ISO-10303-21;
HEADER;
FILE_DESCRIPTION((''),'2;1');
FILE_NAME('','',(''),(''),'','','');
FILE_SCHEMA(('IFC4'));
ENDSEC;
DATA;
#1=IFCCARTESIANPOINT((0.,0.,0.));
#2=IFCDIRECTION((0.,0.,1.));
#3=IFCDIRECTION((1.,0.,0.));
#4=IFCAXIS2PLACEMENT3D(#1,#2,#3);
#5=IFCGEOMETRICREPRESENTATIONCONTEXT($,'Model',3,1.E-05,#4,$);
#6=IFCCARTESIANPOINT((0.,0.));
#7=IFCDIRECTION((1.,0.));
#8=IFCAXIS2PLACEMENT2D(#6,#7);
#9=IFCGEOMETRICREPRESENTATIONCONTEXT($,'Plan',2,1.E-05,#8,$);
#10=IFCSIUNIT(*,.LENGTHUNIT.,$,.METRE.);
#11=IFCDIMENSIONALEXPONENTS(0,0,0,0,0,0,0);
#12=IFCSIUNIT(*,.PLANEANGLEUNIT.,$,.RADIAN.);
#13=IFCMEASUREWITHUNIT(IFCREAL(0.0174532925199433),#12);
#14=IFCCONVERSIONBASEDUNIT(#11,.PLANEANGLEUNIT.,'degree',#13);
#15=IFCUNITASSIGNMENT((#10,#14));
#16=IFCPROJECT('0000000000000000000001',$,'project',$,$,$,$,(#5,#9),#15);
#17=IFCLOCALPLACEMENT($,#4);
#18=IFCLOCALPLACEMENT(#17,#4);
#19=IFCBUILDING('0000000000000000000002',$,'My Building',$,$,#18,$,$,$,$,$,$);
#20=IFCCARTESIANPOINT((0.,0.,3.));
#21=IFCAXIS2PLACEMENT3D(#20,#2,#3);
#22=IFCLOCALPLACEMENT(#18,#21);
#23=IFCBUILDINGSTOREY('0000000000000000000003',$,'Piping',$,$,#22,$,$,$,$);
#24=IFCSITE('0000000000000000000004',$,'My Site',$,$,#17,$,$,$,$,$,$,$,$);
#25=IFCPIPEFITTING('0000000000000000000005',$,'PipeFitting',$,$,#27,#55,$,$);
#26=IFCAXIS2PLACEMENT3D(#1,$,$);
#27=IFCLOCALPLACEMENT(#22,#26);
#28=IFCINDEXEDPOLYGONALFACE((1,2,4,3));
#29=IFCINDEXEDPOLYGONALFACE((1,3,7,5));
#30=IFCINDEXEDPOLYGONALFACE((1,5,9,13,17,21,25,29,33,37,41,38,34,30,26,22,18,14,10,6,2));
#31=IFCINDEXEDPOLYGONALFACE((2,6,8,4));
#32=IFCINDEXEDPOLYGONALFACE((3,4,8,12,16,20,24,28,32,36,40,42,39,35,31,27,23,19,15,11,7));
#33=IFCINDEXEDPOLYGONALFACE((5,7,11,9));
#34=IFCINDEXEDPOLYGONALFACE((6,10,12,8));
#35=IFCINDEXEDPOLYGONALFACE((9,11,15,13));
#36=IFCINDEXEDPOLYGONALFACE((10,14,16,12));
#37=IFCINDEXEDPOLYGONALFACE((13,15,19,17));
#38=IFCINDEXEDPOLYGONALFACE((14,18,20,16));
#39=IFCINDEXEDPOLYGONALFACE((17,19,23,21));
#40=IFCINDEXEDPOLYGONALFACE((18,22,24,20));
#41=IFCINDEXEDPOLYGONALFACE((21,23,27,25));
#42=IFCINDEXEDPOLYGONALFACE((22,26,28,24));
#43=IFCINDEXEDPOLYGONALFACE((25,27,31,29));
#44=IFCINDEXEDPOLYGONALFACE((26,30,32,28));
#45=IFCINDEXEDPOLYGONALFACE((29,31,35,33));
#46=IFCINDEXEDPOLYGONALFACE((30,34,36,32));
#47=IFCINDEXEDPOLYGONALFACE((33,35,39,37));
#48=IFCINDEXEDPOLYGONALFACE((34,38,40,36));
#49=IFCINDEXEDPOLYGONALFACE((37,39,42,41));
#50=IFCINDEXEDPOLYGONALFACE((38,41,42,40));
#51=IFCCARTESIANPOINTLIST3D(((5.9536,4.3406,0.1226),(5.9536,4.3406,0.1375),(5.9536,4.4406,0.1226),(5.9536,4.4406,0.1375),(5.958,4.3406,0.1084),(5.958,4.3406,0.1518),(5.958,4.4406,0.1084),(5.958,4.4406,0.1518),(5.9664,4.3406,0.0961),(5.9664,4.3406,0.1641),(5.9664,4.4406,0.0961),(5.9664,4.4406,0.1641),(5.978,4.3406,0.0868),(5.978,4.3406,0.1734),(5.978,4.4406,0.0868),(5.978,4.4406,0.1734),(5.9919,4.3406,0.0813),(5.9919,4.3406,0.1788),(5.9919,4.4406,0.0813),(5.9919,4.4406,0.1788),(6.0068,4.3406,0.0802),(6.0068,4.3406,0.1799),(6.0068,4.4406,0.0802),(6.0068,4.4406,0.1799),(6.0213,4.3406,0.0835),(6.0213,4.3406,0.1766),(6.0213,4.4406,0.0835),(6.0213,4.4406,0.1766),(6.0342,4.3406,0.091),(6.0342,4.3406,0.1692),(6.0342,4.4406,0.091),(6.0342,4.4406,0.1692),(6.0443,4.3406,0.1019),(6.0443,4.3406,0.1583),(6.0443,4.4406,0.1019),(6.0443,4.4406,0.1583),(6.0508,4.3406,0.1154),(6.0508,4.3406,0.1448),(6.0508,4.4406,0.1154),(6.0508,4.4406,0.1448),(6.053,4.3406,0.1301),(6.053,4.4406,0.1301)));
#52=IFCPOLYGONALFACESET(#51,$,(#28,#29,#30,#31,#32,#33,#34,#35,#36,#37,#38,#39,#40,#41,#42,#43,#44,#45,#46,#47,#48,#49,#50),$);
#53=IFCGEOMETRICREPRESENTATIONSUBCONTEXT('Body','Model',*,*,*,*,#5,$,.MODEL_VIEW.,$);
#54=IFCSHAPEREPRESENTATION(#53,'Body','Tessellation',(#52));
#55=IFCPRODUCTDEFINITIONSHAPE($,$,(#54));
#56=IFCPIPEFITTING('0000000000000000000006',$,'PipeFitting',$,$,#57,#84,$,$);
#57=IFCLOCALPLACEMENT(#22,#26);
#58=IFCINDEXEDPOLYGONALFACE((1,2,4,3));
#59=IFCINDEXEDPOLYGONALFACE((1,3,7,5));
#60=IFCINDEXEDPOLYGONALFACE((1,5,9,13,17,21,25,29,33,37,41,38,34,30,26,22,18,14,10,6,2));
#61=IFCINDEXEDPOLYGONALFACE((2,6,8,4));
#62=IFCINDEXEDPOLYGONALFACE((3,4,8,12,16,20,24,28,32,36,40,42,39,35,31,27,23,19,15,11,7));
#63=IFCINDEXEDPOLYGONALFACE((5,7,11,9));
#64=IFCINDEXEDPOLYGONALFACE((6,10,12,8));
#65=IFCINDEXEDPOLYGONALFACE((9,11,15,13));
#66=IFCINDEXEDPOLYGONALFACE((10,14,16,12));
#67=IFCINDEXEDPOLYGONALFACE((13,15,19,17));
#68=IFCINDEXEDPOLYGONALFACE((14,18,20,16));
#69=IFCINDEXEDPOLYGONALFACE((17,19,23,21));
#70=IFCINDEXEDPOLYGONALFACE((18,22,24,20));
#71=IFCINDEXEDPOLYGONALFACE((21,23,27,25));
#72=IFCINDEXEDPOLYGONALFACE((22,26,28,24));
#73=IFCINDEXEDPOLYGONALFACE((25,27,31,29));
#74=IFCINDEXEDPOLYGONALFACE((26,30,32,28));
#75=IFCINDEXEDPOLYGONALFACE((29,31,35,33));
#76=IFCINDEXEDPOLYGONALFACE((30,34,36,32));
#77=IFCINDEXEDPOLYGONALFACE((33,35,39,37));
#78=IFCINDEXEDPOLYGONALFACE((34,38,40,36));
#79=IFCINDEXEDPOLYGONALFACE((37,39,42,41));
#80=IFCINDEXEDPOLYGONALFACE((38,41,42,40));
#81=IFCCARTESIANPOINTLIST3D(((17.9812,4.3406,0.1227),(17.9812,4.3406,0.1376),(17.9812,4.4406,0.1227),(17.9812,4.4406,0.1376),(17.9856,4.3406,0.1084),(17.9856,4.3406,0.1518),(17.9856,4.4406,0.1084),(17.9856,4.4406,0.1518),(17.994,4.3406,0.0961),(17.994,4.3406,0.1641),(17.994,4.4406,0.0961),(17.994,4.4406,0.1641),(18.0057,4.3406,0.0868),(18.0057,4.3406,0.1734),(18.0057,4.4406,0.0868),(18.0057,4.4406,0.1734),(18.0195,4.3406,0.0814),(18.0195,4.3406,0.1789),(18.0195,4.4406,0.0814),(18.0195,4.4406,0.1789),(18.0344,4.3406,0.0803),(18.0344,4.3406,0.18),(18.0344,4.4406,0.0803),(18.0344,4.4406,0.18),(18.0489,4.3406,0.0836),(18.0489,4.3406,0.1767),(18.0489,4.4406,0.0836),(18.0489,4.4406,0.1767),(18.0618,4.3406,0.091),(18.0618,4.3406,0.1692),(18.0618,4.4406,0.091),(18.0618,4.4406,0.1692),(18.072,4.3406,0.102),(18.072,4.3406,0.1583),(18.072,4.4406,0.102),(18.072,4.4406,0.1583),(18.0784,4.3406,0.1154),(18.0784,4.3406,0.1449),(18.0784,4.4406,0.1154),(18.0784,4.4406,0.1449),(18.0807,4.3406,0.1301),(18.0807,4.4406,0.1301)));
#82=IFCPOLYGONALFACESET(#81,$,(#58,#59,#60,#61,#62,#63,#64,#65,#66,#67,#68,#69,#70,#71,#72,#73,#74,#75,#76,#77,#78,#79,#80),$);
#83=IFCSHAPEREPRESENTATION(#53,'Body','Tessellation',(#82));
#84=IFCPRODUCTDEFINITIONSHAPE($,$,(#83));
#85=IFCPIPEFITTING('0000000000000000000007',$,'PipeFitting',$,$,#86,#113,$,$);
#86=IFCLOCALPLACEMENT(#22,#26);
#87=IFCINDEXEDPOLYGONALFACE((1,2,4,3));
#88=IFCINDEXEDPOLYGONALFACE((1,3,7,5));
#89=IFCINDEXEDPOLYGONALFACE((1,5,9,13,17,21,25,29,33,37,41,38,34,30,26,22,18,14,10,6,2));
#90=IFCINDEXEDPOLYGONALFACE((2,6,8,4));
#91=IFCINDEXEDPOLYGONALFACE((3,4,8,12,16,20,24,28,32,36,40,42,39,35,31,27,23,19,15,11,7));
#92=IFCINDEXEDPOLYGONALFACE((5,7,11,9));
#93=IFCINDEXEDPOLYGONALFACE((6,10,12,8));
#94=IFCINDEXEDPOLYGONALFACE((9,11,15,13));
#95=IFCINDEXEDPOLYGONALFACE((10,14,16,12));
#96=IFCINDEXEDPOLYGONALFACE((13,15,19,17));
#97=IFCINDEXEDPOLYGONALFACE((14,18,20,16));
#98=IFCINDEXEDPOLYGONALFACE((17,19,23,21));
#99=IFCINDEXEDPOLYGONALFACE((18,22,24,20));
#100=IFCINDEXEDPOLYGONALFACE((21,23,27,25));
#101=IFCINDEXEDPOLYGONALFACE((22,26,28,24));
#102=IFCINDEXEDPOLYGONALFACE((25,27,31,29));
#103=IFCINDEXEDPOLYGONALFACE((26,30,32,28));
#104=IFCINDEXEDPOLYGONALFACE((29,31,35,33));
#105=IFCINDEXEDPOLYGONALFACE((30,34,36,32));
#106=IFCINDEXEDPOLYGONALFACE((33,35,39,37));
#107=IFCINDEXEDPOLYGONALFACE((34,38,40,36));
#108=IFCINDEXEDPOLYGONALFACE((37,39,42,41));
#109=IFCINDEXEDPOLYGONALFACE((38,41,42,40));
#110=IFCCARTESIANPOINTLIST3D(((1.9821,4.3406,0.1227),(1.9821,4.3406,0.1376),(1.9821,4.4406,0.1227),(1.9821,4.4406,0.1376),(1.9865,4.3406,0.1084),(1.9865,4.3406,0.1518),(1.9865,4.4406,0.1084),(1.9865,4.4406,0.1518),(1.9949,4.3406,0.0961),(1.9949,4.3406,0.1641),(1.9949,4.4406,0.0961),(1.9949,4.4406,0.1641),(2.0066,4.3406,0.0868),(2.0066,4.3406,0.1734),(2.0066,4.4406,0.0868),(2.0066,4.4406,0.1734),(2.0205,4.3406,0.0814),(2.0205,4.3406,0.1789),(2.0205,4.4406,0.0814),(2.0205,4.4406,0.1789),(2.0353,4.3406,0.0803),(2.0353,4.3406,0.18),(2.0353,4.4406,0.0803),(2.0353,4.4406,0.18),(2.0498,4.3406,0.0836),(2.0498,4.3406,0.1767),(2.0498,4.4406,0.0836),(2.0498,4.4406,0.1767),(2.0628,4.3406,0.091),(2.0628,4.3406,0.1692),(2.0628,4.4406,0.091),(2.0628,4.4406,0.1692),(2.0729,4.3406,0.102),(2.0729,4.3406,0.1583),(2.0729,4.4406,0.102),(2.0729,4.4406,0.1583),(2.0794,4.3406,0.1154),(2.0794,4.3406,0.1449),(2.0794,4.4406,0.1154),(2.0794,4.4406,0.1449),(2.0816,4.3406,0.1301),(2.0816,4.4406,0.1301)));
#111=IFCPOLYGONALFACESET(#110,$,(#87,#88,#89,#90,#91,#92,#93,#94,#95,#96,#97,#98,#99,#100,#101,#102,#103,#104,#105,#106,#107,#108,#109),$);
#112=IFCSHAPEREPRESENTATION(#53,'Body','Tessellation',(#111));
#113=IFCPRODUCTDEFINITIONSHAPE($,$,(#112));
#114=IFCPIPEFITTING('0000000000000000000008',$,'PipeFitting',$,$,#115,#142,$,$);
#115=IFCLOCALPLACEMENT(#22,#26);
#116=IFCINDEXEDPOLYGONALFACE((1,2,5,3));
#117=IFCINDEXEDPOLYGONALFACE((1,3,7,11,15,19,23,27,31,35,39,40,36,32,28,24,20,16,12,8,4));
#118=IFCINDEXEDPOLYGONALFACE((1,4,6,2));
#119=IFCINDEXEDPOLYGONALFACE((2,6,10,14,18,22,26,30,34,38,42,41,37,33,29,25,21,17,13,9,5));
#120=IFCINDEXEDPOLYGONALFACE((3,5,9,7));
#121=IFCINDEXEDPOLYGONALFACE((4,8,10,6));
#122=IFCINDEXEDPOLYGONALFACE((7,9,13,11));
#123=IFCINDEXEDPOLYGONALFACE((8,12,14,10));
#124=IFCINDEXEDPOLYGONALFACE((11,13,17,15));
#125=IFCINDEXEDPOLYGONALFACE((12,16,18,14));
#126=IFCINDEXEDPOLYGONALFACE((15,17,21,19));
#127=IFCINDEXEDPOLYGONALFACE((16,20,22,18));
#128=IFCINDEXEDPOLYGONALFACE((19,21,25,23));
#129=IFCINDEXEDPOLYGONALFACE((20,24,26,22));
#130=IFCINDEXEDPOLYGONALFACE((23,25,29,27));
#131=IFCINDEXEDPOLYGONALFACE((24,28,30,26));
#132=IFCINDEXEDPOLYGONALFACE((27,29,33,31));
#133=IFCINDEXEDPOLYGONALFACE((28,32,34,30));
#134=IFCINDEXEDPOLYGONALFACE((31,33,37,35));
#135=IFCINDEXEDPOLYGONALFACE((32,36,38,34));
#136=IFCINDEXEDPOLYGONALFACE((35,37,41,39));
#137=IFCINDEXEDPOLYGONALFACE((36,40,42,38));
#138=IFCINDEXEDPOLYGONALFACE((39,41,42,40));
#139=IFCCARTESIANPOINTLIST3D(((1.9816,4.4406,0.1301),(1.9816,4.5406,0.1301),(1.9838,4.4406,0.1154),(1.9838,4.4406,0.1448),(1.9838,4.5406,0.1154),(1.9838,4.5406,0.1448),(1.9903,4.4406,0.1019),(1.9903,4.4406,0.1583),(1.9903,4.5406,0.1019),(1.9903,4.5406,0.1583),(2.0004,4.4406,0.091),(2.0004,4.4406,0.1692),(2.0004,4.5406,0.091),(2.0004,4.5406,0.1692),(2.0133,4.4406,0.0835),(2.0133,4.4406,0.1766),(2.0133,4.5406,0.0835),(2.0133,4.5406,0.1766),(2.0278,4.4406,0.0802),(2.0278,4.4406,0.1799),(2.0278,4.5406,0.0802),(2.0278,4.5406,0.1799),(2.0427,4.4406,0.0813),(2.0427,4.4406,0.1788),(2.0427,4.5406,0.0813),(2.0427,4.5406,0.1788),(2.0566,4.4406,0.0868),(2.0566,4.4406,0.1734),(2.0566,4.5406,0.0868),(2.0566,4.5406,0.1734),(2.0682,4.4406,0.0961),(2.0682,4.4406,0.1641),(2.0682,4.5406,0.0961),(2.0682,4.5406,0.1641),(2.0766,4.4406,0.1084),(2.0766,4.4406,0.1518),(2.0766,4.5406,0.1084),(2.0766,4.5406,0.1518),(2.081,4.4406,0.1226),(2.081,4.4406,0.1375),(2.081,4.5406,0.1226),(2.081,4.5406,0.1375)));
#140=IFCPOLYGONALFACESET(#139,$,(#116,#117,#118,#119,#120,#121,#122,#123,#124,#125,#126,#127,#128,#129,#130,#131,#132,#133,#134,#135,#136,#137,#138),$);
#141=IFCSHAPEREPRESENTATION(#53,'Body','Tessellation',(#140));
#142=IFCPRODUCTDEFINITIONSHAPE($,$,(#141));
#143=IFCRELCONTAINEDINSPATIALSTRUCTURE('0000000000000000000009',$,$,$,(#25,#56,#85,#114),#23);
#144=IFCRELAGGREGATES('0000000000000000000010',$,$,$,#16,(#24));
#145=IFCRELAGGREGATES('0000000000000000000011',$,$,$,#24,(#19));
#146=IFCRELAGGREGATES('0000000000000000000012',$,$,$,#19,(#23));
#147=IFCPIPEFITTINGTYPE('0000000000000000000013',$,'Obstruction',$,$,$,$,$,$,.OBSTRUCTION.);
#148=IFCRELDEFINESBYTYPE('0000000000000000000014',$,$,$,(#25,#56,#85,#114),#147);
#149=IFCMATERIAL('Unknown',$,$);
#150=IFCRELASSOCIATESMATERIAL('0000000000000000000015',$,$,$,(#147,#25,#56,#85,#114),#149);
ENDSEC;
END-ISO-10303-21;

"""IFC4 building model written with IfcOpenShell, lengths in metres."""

from ifc_helpers import new_model, entity, si_unit, converted_unit, frame, origin_with_axes, origin_2d_with_axis, place, context, subcontext, project, spatial, circle, extrude, material, material_profile, profile_set, profile_usage, type_object, element, save


model = new_model("IFC4")

# Units and contexts
model_context = context("Model", 3, precision=1e-05, world=origin_with_axes())
plan_context = context("Plan", 2, precision=1e-05, world=origin_2d_with_axis())
body_context = subcontext(model_context, "Body", "Model", "MODEL_VIEW")
ifc_project = project(units=[si_unit("LENGTHUNIT", "METRE"), converted_unit("PLANEANGLEUNIT", "degree", entity("IfcReal", 0.0174532925199433), si_unit("PLANEANGLEUNIT", "RADIAN"), dimensions=[0, 0, 0, 0, 0, 0, 0])], contexts=[model_context, plan_context])

# Site, building, storey
site_placement = place(None, origin_with_axes())
site = spatial("IfcSite", under=ifc_project, at=site_placement, Name="My Site")
building_placement = place(site_placement, origin_with_axes())
building = spatial("IfcBuilding", under=site, at=building_placement, Name="My Building")
storey_placement = place(building_placement, frame((0.0, 0.0, 3.0), z_axis=(0.0, 0.0, 1.0), x_axis=(1.0, 0.0, 0.0)))
storey = spatial("IfcBuildingStorey", under=building, at=storey_placement, Name="Piping")

# Shared definitions
ifc_material = material(Name="Unknown")

# Pipe fittings
ifc_material_profile_1 = material_profile(ifc_material, circle(Radius=0.05))
ifc_profile_set_1 = profile_set([ifc_material_profile_1])
pipe_fitting_type_1 = type_object("IfcPipeFittingType", Name="Obstruction", PredefinedType="OBSTRUCTION", material=ifc_profile_set_1)
ifc_profile_usage_1 = profile_usage(ifc_profile_set_1, cardinal=5)
pipe_fitting_1_placement = place(storey_placement, frame((6.003, 4.4406, 0.1301), z_axis=(0.0, -1.0, 0.000015), x_axis=(1.0, 0.0, 0.0)))
element("IfcPipeFitting", 1, at=pipe_fitting_1_placement, inside=storey, type_object=pipe_fitting_type_1, material=ifc_profile_usage_1, Name="PipeFitting", context=body_context, shape_type="SweptSolid", body=[
    extrude(circle(Radius=0.05), origin_with_axes(), (0.0, 0.0, 1.0), 0.1),
])
ifc_profile_usage_2 = profile_usage(ifc_profile_set_1, cardinal=5)
pipe_fitting_2_placement = place(storey_placement, frame((18.0307, 4.4406, 0.1301), z_axis=(0.0, -1.0, 0.000015), x_axis=(1.0, 0.0, 0.0)))
element("IfcPipeFitting", 2, at=pipe_fitting_2_placement, inside=storey, type_object=pipe_fitting_type_1, material=ifc_profile_usage_2, Name="PipeFitting", context=body_context, shape_type="SweptSolid", body=[
    extrude(circle(Radius=0.05), origin_with_axes(), (0.0, 0.0, 1.0), 0.1),
])
ifc_profile_usage_3 = profile_usage(ifc_profile_set_1, cardinal=5)
pipe_fitting_3_placement = place(storey_placement, frame((2.0316, 4.4406, 0.1301), z_axis=(0.0, -1.0, 0.000015), x_axis=(1.0, 0.0, 0.0)))
element("IfcPipeFitting", 3, at=pipe_fitting_3_placement, inside=storey, type_object=pipe_fitting_type_1, material=ifc_profile_usage_3, Name="PipeFitting", context=body_context, shape_type="SweptSolid", body=[
    extrude(circle(Radius=0.05), origin_with_axes(), (0.0, 0.0, 1.0), 0.1),
])
ifc_profile_usage_4 = profile_usage(ifc_profile_set_1, cardinal=5)
pipe_fitting_4_placement = place(storey_placement, frame((2.0316, 4.4406, 0.1301), z_axis=(0.0, 1.0, -0.000001), x_axis=(-1.0, 0.0, 0.0)))
element("IfcPipeFitting", 4, at=pipe_fitting_4_placement, inside=storey, type_object=pipe_fitting_type_1, material=ifc_profile_usage_4, Name="PipeFitting", context=body_context, shape_type="SweptSolid", body=[
    extrude(circle(Radius=0.05), origin_with_axes(), (0.0, 0.0, 1.0), 0.1),
])

save(model, "model.ifc")
